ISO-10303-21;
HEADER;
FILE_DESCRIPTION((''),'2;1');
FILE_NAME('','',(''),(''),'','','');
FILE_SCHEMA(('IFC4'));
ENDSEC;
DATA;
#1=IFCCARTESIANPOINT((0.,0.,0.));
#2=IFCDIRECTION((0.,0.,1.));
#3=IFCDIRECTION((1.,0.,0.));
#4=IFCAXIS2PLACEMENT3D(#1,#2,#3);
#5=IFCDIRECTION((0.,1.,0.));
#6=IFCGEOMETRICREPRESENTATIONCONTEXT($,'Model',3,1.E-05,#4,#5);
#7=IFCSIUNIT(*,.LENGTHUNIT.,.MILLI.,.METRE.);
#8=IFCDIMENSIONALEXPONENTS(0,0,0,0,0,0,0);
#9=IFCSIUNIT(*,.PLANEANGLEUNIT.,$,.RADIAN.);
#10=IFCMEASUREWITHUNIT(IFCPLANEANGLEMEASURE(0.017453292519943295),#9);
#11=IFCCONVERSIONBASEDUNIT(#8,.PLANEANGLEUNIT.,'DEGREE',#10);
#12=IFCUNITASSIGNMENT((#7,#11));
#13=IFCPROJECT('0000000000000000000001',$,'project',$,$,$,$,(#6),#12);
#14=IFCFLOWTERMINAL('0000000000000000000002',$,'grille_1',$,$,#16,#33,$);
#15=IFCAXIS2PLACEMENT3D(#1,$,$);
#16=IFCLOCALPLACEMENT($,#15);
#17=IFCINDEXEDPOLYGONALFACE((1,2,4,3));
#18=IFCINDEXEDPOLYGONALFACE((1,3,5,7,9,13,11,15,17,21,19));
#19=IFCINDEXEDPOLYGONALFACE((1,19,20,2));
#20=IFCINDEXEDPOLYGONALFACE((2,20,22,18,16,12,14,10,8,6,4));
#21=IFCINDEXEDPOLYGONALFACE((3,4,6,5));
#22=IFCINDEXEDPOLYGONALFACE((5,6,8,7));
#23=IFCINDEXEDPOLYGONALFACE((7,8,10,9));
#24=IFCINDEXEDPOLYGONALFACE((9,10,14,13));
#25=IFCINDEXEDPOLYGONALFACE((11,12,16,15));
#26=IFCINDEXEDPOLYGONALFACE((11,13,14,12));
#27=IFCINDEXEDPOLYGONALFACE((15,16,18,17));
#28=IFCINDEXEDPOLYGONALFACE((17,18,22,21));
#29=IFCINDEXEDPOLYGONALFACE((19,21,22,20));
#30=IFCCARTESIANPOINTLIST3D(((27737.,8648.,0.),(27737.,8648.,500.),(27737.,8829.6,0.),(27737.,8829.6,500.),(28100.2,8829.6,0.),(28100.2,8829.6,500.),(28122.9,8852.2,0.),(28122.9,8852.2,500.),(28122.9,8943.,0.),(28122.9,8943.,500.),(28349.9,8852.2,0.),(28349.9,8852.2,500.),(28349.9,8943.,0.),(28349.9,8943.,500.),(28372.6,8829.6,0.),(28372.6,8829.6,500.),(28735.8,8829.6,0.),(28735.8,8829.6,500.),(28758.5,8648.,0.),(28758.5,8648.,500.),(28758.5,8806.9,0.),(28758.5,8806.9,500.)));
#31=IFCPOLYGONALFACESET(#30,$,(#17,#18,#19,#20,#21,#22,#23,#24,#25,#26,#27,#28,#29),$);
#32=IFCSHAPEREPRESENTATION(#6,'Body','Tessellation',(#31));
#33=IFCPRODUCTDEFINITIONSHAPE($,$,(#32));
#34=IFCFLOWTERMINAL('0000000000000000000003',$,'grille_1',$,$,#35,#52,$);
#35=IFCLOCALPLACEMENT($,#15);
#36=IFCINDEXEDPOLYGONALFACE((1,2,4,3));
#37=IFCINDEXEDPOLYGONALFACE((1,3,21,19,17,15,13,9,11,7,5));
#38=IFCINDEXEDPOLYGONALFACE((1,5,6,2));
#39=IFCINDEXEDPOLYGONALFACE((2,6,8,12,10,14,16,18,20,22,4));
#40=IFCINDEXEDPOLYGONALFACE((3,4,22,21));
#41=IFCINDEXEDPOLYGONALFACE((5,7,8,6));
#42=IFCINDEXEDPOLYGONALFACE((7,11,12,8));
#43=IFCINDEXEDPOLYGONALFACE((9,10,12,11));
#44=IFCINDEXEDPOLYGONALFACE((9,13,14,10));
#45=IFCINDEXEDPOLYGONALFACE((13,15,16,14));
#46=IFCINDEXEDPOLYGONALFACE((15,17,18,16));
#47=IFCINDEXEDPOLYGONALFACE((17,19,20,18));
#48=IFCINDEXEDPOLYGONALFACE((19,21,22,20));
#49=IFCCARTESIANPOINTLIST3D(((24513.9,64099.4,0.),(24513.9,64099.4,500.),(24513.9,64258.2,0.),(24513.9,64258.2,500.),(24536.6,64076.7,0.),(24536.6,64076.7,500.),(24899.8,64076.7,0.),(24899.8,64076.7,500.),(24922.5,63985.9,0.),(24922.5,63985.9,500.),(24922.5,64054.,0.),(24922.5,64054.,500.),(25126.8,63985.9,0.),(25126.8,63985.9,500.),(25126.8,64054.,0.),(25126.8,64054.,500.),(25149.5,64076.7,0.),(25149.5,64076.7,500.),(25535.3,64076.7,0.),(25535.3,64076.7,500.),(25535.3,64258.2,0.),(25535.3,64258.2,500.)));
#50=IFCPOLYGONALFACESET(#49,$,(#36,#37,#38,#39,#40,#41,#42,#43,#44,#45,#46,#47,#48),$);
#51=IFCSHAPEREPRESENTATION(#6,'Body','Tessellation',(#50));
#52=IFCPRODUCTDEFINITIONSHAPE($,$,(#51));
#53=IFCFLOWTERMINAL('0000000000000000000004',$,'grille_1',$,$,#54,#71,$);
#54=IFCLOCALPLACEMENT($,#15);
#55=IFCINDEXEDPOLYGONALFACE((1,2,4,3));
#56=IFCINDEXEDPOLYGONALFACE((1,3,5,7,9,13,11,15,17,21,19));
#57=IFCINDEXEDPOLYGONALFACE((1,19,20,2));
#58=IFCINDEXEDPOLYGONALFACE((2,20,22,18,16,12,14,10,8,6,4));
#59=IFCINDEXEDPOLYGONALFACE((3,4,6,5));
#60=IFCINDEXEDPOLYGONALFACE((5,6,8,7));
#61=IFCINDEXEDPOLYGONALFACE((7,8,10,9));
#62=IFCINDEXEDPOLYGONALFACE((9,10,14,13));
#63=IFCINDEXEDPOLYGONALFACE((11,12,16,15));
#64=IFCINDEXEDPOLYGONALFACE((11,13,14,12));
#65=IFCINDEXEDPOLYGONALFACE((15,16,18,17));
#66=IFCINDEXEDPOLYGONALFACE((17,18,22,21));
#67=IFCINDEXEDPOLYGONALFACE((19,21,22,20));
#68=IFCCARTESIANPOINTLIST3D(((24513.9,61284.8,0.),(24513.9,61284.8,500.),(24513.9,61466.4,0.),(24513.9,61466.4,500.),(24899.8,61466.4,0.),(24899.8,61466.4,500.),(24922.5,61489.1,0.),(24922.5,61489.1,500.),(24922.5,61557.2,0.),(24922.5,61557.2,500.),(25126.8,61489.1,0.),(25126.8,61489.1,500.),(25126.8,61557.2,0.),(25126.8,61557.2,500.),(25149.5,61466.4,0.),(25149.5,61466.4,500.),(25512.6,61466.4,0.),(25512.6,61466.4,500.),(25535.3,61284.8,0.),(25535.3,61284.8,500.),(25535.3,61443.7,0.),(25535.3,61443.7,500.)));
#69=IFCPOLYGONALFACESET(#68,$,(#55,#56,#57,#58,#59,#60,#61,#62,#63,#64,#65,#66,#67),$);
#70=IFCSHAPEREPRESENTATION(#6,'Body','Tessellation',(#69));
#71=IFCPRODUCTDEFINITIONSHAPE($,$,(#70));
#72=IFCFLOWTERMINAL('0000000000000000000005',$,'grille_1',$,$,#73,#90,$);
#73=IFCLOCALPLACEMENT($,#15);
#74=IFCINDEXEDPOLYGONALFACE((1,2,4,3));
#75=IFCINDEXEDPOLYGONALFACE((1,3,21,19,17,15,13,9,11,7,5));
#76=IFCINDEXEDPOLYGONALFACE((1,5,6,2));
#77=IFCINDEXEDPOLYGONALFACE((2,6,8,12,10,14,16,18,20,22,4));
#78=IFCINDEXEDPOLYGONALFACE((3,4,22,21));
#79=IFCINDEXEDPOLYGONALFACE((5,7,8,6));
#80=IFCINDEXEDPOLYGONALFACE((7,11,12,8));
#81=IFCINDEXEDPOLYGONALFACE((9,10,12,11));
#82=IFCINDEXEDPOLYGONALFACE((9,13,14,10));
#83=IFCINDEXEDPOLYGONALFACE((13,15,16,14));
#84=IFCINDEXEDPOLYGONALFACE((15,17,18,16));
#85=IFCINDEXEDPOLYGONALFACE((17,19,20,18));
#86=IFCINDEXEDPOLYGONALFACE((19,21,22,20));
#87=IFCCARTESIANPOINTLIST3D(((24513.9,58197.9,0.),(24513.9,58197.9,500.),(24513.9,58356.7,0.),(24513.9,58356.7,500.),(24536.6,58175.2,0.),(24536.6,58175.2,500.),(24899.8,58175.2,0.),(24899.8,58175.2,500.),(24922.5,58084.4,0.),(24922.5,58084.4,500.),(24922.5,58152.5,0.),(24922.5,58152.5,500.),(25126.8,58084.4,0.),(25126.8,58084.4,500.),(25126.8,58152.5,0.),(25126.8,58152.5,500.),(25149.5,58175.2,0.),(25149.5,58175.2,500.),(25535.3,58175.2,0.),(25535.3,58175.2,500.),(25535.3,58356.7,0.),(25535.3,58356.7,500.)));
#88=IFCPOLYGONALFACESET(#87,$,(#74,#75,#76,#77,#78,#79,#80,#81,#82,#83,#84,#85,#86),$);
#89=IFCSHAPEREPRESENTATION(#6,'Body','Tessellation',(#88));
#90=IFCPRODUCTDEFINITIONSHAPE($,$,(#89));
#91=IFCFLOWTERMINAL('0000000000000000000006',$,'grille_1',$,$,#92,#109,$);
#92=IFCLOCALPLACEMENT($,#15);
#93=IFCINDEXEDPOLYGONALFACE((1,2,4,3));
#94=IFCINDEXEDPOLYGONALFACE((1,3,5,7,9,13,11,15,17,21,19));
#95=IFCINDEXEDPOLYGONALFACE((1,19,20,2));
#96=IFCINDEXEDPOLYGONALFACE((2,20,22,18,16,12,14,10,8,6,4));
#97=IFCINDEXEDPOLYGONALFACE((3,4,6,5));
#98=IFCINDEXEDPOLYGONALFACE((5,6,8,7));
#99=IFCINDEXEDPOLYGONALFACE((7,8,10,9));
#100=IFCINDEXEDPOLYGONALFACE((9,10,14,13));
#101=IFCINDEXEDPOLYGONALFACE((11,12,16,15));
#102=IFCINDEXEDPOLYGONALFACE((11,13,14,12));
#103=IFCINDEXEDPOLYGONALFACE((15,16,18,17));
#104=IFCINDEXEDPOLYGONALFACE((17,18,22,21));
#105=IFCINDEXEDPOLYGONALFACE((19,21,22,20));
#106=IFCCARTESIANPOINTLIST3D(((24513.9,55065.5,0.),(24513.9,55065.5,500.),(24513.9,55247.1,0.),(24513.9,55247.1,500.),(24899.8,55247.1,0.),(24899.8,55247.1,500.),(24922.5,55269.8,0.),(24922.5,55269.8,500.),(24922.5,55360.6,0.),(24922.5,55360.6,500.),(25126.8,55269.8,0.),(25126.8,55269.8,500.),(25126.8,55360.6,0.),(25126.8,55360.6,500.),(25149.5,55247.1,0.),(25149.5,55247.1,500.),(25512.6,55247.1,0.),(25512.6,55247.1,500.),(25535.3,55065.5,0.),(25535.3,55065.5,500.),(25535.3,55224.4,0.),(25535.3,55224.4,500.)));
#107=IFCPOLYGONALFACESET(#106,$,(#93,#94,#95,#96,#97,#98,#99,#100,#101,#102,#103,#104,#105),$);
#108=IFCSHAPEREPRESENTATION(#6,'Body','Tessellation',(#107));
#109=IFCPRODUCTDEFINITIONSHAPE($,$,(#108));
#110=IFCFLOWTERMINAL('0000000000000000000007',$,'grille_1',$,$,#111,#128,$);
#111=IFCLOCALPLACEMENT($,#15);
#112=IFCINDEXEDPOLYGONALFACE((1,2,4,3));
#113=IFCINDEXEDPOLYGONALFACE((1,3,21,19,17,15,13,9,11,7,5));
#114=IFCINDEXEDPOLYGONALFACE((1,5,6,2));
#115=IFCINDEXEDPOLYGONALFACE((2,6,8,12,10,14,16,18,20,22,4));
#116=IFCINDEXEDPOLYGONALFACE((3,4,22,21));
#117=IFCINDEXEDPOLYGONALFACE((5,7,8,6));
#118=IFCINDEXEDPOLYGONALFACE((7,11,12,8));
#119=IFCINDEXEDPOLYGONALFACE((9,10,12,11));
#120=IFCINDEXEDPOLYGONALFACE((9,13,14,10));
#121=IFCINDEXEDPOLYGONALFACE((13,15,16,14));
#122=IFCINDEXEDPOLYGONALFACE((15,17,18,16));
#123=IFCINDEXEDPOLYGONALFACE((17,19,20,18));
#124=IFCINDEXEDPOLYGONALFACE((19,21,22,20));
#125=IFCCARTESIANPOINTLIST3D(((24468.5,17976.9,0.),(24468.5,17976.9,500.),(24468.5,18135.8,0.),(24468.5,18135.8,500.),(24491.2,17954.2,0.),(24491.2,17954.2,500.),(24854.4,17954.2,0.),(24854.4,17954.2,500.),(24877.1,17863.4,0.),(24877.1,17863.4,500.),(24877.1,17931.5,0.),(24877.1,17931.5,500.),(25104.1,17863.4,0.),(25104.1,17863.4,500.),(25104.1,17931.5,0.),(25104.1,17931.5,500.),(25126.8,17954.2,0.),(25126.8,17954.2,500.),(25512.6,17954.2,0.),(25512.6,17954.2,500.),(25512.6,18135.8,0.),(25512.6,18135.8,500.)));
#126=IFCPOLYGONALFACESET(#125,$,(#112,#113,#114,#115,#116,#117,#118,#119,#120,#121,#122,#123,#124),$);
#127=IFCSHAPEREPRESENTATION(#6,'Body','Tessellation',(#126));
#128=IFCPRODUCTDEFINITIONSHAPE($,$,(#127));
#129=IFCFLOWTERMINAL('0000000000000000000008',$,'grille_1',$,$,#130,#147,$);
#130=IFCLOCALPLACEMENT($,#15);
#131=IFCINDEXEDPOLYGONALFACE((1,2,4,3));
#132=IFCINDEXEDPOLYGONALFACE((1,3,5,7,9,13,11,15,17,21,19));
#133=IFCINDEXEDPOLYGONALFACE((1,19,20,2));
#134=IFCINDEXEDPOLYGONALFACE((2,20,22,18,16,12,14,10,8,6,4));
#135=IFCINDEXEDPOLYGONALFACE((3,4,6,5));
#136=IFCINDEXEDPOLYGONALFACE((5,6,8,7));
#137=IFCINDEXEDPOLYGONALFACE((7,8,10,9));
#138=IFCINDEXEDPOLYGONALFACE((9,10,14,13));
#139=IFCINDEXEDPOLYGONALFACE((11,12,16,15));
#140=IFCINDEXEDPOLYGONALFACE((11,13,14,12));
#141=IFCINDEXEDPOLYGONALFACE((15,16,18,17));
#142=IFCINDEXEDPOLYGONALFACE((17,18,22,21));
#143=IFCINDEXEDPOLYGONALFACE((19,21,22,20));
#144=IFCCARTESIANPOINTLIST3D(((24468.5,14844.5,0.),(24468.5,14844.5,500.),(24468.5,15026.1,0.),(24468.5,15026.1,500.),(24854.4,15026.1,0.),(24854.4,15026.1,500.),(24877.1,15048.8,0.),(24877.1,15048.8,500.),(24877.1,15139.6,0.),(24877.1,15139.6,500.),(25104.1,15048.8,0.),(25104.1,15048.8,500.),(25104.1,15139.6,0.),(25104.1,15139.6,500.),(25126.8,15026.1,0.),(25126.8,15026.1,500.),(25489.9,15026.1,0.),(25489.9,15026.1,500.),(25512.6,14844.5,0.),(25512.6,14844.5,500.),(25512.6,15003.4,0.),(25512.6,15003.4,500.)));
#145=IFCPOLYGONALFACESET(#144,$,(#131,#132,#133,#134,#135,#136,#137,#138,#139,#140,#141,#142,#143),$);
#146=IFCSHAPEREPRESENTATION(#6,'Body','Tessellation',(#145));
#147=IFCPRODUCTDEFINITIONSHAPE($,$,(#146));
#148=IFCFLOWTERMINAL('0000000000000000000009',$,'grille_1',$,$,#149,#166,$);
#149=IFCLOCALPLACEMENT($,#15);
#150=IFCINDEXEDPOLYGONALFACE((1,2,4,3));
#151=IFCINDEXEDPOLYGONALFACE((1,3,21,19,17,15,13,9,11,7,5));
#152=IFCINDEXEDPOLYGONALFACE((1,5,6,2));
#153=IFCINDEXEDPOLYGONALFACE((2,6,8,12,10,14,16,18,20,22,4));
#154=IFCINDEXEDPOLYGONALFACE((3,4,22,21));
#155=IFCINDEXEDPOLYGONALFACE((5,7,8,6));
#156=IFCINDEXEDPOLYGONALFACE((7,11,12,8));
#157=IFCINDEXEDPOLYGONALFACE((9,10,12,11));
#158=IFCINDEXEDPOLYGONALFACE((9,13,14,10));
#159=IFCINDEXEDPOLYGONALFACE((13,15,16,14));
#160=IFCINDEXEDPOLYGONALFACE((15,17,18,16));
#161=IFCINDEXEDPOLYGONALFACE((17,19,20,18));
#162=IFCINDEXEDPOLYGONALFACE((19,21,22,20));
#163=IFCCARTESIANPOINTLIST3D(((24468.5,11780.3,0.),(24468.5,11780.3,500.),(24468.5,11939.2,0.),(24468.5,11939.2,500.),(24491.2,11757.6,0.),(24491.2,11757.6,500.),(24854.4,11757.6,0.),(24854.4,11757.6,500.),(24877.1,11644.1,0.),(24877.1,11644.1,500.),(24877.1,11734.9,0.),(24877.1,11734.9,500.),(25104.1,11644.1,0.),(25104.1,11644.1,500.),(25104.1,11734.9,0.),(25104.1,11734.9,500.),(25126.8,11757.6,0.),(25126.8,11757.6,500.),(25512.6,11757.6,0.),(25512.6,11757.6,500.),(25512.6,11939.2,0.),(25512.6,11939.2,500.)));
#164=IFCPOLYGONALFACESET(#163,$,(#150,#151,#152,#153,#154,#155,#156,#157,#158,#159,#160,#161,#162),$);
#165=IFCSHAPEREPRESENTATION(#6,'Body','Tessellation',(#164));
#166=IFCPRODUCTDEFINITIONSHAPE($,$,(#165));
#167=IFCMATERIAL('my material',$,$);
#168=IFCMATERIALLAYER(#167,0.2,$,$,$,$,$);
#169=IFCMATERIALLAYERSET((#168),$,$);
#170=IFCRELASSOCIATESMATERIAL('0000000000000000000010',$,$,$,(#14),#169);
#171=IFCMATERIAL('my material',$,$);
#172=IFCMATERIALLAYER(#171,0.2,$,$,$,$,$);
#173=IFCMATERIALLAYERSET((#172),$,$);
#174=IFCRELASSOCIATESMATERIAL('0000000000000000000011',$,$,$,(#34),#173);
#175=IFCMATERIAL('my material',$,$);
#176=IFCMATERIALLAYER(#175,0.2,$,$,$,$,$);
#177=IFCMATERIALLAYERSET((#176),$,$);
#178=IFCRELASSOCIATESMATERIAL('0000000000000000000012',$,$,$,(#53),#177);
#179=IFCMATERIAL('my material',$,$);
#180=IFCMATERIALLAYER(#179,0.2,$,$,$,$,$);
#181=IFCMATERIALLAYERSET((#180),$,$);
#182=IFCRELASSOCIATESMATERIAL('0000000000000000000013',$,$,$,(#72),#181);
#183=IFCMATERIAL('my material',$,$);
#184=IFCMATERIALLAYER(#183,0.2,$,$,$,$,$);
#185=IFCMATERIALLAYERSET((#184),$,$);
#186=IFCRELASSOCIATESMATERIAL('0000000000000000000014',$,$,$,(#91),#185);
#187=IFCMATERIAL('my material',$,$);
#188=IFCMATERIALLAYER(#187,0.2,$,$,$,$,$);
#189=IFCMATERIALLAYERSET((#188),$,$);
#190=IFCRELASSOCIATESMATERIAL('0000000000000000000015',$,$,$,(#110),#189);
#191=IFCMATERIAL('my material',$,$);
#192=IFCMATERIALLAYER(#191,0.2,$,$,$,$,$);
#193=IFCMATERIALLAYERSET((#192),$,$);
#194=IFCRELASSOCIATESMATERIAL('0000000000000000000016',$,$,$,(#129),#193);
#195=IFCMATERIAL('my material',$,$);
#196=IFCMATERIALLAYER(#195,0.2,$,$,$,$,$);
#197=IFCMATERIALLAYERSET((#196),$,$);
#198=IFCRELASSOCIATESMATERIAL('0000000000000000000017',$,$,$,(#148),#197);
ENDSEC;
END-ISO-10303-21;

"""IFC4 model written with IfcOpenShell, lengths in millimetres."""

from ifc_helpers import new_model, entity, si_unit, converted_unit, direction, origin_with_axes, place, context, project, polyline, outline, extrude, material, layer, layer_set, layer_usage, element, save


model = new_model("IFC4")

# Units and contexts
model_context = context("Model", 3, precision=1e-05, world=origin_with_axes(), true_north=direction((0.0, 1.0, 0.0)))
ifc_project = project(units=[si_unit("LENGTHUNIT", "METRE", prefix="MILLI"), converted_unit("PLANEANGLEUNIT", "DEGREE", entity("IfcPlaneAngleMeasure", 0.017453292519943295), si_unit("PLANEANGLEUNIT", "RADIAN"), dimensions=[0, 0, 0, 0, 0, 0, 0])], contexts=[model_context])

# Flow terminals
ifc_material_1 = material(Name="my material")
ifc_layer_1 = layer(ifc_material_1, 0.2)
ifc_layer_set_1 = layer_set([ifc_layer_1])
ifc_layer_usage_1 = layer_usage(ifc_layer_set_1, "AXIS2", "POSITIVE", -0.1)
flow_terminal_1_placement = place(None, origin_with_axes())
element("IfcFlowTerminal", 1, at=flow_terminal_1_placement, material=ifc_layer_usage_1, Name="grille_1", context=model_context, shape_type="SweptSolid", body=[
    extrude(outline(polyline([(27737.0, 8648.0), (28758.5, 8648.0), (28758.5, 8806.9), (28735.8, 8829.6), (28372.6, 8829.6), (28349.9, 8852.2), (28349.9, 8943.0), (28122.9, 8943.0), (28122.9, 8852.2), (28100.2, 8829.6), (27737.0, 8829.6), (27737.0, 8648.0)])), origin_with_axes(), (0.0, 0.0, 1.0), 500.0),
])
ifc_material_2 = material(Name="my material")
ifc_layer_2 = layer(ifc_material_2, 0.2)
ifc_layer_set_2 = layer_set([ifc_layer_2])
ifc_layer_usage_2 = layer_usage(ifc_layer_set_2, "AXIS2", "POSITIVE", -0.1)
flow_terminal_2_placement = place(None, origin_with_axes())
element("IfcFlowTerminal", 2, at=flow_terminal_2_placement, material=ifc_layer_usage_2, Name="grille_1", context=model_context, shape_type="SweptSolid", body=[
    extrude(outline(polyline([(24513.9, 64099.4), (24536.6, 64076.7), (24899.8, 64076.7), (24922.5, 64054.0), (24922.5, 63985.9), (25126.8, 63985.9), (25126.8, 64054.0), (25149.5, 64076.7), (25535.3, 64076.7), (25535.3, 64258.2), (24513.9, 64258.2), (24513.9, 64099.4)])), origin_with_axes(), (0.0, 0.0, 1.0), 500.0),
])
ifc_material_3 = material(Name="my material")
ifc_layer_3 = layer(ifc_material_3, 0.2)
ifc_layer_set_3 = layer_set([ifc_layer_3])
ifc_layer_usage_3 = layer_usage(ifc_layer_set_3, "AXIS2", "POSITIVE", -0.1)
flow_terminal_3_placement = place(None, origin_with_axes())
element("IfcFlowTerminal", 3, at=flow_terminal_3_placement, material=ifc_layer_usage_3, Name="grille_1", context=model_context, shape_type="SweptSolid", body=[
    extrude(outline(polyline([(24513.9, 61284.8), (25535.3, 61284.8), (25535.3, 61443.7), (25512.6, 61466.4), (25149.5, 61466.4), (25126.8, 61489.1), (25126.8, 61557.2), (24922.5, 61557.2), (24922.5, 61489.1), (24899.8, 61466.4), (24513.9, 61466.4), (24513.9, 61284.8)])), origin_with_axes(), (0.0, 0.0, 1.0), 500.0),
])
ifc_material_4 = material(Name="my material")
ifc_layer_4 = layer(ifc_material_4, 0.2)
ifc_layer_set_4 = layer_set([ifc_layer_4])
ifc_layer_usage_4 = layer_usage(ifc_layer_set_4, "AXIS2", "POSITIVE", -0.1)
flow_terminal_4_placement = place(None, origin_with_axes())
element("IfcFlowTerminal", 4, at=flow_terminal_4_placement, material=ifc_layer_usage_4, Name="grille_1", context=model_context, shape_type="SweptSolid", body=[
    extrude(outline(polyline([(24513.9, 58197.9), (24536.6, 58175.2), (24899.8, 58175.2), (24922.5, 58152.5), (24922.5, 58084.4), (25126.8, 58084.4), (25126.8, 58152.5), (25149.5, 58175.2), (25535.3, 58175.2), (25535.3, 58356.7), (24513.9, 58356.7), (24513.9, 58197.9)])), origin_with_axes(), (0.0, 0.0, 1.0), 500.0),
])
ifc_material_5 = material(Name="my material")
ifc_layer_5 = layer(ifc_material_5, 0.2)
ifc_layer_set_5 = layer_set([ifc_layer_5])
ifc_layer_usage_5 = layer_usage(ifc_layer_set_5, "AXIS2", "POSITIVE", -0.1)
flow_terminal_5_placement = place(None, origin_with_axes())
element("IfcFlowTerminal", 5, at=flow_terminal_5_placement, material=ifc_layer_usage_5, Name="grille_1", context=model_context, shape_type="SweptSolid", body=[
    extrude(outline(polyline([(24513.9, 55065.5), (25535.3, 55065.5), (25535.3, 55224.4), (25512.6, 55247.1), (25149.5, 55247.1), (25126.8, 55269.8), (25126.8, 55360.6), (24922.5, 55360.6), (24922.5, 55269.8), (24899.8, 55247.1), (24513.9, 55247.1), (24513.9, 55065.5)])), origin_with_axes(), (0.0, 0.0, 1.0), 500.0),
])
ifc_material_6 = material(Name="my material")
ifc_layer_6 = layer(ifc_material_6, 0.2)
ifc_layer_set_6 = layer_set([ifc_layer_6])
ifc_layer_usage_6 = layer_usage(ifc_layer_set_6, "AXIS2", "POSITIVE", -0.1)
flow_terminal_6_placement = place(None, origin_with_axes())
element("IfcFlowTerminal", 6, at=flow_terminal_6_placement, material=ifc_layer_usage_6, Name="grille_1", context=model_context, shape_type="SweptSolid", body=[
    extrude(outline(polyline([(24468.5, 17976.9), (24491.2, 17954.2), (24854.4, 17954.2), (24877.1, 17931.5), (24877.1, 17863.4), (25104.1, 17863.4), (25104.1, 17931.5), (25126.8, 17954.2), (25512.6, 17954.2), (25512.6, 18135.8), (24468.5, 18135.8), (24468.5, 17976.9)])), origin_with_axes(), (0.0, 0.0, 1.0), 500.0),
])
ifc_material_7 = material(Name="my material")
ifc_layer_7 = layer(ifc_material_7, 0.2)
ifc_layer_set_7 = layer_set([ifc_layer_7])
ifc_layer_usage_7 = layer_usage(ifc_layer_set_7, "AXIS2", "POSITIVE", -0.1)
flow_terminal_7_placement = place(None, origin_with_axes())
element("IfcFlowTerminal", 7, at=flow_terminal_7_placement, material=ifc_layer_usage_7, Name="grille_1", context=model_context, shape_type="SweptSolid", body=[
    extrude(outline(polyline([(24468.5, 14844.5), (25512.6, 14844.5), (25512.6, 15003.4), (25489.9, 15026.1), (25126.8, 15026.1), (25104.1, 15048.8), (25104.1, 15139.6), (24877.1, 15139.6), (24877.1, 15048.8), (24854.4, 15026.1), (24468.5, 15026.1), (24468.5, 14844.5)])), origin_with_axes(), (0.0, 0.0, 1.0), 500.0),
])
ifc_material_8 = material(Name="my material")
ifc_layer_8 = layer(ifc_material_8, 0.2)
ifc_layer_set_8 = layer_set([ifc_layer_8])
ifc_layer_usage_8 = layer_usage(ifc_layer_set_8, "AXIS2", "POSITIVE", -0.1)
flow_terminal_8_placement = place(None, origin_with_axes())
element("IfcFlowTerminal", 8, at=flow_terminal_8_placement, material=ifc_layer_usage_8, Name="grille_1", context=model_context, shape_type="SweptSolid", body=[
    extrude(outline(polyline([(24468.5, 11780.3), (24491.2, 11757.6), (24854.4, 11757.6), (24877.1, 11734.9), (24877.1, 11644.1), (25104.1, 11644.1), (25104.1, 11734.9), (25126.8, 11757.6), (25512.6, 11757.6), (25512.6, 11939.2), (24468.5, 11939.2), (24468.5, 11780.3)])), origin_with_axes(), (0.0, 0.0, 1.0), 500.0),
])

save(model, "model.ifc")
